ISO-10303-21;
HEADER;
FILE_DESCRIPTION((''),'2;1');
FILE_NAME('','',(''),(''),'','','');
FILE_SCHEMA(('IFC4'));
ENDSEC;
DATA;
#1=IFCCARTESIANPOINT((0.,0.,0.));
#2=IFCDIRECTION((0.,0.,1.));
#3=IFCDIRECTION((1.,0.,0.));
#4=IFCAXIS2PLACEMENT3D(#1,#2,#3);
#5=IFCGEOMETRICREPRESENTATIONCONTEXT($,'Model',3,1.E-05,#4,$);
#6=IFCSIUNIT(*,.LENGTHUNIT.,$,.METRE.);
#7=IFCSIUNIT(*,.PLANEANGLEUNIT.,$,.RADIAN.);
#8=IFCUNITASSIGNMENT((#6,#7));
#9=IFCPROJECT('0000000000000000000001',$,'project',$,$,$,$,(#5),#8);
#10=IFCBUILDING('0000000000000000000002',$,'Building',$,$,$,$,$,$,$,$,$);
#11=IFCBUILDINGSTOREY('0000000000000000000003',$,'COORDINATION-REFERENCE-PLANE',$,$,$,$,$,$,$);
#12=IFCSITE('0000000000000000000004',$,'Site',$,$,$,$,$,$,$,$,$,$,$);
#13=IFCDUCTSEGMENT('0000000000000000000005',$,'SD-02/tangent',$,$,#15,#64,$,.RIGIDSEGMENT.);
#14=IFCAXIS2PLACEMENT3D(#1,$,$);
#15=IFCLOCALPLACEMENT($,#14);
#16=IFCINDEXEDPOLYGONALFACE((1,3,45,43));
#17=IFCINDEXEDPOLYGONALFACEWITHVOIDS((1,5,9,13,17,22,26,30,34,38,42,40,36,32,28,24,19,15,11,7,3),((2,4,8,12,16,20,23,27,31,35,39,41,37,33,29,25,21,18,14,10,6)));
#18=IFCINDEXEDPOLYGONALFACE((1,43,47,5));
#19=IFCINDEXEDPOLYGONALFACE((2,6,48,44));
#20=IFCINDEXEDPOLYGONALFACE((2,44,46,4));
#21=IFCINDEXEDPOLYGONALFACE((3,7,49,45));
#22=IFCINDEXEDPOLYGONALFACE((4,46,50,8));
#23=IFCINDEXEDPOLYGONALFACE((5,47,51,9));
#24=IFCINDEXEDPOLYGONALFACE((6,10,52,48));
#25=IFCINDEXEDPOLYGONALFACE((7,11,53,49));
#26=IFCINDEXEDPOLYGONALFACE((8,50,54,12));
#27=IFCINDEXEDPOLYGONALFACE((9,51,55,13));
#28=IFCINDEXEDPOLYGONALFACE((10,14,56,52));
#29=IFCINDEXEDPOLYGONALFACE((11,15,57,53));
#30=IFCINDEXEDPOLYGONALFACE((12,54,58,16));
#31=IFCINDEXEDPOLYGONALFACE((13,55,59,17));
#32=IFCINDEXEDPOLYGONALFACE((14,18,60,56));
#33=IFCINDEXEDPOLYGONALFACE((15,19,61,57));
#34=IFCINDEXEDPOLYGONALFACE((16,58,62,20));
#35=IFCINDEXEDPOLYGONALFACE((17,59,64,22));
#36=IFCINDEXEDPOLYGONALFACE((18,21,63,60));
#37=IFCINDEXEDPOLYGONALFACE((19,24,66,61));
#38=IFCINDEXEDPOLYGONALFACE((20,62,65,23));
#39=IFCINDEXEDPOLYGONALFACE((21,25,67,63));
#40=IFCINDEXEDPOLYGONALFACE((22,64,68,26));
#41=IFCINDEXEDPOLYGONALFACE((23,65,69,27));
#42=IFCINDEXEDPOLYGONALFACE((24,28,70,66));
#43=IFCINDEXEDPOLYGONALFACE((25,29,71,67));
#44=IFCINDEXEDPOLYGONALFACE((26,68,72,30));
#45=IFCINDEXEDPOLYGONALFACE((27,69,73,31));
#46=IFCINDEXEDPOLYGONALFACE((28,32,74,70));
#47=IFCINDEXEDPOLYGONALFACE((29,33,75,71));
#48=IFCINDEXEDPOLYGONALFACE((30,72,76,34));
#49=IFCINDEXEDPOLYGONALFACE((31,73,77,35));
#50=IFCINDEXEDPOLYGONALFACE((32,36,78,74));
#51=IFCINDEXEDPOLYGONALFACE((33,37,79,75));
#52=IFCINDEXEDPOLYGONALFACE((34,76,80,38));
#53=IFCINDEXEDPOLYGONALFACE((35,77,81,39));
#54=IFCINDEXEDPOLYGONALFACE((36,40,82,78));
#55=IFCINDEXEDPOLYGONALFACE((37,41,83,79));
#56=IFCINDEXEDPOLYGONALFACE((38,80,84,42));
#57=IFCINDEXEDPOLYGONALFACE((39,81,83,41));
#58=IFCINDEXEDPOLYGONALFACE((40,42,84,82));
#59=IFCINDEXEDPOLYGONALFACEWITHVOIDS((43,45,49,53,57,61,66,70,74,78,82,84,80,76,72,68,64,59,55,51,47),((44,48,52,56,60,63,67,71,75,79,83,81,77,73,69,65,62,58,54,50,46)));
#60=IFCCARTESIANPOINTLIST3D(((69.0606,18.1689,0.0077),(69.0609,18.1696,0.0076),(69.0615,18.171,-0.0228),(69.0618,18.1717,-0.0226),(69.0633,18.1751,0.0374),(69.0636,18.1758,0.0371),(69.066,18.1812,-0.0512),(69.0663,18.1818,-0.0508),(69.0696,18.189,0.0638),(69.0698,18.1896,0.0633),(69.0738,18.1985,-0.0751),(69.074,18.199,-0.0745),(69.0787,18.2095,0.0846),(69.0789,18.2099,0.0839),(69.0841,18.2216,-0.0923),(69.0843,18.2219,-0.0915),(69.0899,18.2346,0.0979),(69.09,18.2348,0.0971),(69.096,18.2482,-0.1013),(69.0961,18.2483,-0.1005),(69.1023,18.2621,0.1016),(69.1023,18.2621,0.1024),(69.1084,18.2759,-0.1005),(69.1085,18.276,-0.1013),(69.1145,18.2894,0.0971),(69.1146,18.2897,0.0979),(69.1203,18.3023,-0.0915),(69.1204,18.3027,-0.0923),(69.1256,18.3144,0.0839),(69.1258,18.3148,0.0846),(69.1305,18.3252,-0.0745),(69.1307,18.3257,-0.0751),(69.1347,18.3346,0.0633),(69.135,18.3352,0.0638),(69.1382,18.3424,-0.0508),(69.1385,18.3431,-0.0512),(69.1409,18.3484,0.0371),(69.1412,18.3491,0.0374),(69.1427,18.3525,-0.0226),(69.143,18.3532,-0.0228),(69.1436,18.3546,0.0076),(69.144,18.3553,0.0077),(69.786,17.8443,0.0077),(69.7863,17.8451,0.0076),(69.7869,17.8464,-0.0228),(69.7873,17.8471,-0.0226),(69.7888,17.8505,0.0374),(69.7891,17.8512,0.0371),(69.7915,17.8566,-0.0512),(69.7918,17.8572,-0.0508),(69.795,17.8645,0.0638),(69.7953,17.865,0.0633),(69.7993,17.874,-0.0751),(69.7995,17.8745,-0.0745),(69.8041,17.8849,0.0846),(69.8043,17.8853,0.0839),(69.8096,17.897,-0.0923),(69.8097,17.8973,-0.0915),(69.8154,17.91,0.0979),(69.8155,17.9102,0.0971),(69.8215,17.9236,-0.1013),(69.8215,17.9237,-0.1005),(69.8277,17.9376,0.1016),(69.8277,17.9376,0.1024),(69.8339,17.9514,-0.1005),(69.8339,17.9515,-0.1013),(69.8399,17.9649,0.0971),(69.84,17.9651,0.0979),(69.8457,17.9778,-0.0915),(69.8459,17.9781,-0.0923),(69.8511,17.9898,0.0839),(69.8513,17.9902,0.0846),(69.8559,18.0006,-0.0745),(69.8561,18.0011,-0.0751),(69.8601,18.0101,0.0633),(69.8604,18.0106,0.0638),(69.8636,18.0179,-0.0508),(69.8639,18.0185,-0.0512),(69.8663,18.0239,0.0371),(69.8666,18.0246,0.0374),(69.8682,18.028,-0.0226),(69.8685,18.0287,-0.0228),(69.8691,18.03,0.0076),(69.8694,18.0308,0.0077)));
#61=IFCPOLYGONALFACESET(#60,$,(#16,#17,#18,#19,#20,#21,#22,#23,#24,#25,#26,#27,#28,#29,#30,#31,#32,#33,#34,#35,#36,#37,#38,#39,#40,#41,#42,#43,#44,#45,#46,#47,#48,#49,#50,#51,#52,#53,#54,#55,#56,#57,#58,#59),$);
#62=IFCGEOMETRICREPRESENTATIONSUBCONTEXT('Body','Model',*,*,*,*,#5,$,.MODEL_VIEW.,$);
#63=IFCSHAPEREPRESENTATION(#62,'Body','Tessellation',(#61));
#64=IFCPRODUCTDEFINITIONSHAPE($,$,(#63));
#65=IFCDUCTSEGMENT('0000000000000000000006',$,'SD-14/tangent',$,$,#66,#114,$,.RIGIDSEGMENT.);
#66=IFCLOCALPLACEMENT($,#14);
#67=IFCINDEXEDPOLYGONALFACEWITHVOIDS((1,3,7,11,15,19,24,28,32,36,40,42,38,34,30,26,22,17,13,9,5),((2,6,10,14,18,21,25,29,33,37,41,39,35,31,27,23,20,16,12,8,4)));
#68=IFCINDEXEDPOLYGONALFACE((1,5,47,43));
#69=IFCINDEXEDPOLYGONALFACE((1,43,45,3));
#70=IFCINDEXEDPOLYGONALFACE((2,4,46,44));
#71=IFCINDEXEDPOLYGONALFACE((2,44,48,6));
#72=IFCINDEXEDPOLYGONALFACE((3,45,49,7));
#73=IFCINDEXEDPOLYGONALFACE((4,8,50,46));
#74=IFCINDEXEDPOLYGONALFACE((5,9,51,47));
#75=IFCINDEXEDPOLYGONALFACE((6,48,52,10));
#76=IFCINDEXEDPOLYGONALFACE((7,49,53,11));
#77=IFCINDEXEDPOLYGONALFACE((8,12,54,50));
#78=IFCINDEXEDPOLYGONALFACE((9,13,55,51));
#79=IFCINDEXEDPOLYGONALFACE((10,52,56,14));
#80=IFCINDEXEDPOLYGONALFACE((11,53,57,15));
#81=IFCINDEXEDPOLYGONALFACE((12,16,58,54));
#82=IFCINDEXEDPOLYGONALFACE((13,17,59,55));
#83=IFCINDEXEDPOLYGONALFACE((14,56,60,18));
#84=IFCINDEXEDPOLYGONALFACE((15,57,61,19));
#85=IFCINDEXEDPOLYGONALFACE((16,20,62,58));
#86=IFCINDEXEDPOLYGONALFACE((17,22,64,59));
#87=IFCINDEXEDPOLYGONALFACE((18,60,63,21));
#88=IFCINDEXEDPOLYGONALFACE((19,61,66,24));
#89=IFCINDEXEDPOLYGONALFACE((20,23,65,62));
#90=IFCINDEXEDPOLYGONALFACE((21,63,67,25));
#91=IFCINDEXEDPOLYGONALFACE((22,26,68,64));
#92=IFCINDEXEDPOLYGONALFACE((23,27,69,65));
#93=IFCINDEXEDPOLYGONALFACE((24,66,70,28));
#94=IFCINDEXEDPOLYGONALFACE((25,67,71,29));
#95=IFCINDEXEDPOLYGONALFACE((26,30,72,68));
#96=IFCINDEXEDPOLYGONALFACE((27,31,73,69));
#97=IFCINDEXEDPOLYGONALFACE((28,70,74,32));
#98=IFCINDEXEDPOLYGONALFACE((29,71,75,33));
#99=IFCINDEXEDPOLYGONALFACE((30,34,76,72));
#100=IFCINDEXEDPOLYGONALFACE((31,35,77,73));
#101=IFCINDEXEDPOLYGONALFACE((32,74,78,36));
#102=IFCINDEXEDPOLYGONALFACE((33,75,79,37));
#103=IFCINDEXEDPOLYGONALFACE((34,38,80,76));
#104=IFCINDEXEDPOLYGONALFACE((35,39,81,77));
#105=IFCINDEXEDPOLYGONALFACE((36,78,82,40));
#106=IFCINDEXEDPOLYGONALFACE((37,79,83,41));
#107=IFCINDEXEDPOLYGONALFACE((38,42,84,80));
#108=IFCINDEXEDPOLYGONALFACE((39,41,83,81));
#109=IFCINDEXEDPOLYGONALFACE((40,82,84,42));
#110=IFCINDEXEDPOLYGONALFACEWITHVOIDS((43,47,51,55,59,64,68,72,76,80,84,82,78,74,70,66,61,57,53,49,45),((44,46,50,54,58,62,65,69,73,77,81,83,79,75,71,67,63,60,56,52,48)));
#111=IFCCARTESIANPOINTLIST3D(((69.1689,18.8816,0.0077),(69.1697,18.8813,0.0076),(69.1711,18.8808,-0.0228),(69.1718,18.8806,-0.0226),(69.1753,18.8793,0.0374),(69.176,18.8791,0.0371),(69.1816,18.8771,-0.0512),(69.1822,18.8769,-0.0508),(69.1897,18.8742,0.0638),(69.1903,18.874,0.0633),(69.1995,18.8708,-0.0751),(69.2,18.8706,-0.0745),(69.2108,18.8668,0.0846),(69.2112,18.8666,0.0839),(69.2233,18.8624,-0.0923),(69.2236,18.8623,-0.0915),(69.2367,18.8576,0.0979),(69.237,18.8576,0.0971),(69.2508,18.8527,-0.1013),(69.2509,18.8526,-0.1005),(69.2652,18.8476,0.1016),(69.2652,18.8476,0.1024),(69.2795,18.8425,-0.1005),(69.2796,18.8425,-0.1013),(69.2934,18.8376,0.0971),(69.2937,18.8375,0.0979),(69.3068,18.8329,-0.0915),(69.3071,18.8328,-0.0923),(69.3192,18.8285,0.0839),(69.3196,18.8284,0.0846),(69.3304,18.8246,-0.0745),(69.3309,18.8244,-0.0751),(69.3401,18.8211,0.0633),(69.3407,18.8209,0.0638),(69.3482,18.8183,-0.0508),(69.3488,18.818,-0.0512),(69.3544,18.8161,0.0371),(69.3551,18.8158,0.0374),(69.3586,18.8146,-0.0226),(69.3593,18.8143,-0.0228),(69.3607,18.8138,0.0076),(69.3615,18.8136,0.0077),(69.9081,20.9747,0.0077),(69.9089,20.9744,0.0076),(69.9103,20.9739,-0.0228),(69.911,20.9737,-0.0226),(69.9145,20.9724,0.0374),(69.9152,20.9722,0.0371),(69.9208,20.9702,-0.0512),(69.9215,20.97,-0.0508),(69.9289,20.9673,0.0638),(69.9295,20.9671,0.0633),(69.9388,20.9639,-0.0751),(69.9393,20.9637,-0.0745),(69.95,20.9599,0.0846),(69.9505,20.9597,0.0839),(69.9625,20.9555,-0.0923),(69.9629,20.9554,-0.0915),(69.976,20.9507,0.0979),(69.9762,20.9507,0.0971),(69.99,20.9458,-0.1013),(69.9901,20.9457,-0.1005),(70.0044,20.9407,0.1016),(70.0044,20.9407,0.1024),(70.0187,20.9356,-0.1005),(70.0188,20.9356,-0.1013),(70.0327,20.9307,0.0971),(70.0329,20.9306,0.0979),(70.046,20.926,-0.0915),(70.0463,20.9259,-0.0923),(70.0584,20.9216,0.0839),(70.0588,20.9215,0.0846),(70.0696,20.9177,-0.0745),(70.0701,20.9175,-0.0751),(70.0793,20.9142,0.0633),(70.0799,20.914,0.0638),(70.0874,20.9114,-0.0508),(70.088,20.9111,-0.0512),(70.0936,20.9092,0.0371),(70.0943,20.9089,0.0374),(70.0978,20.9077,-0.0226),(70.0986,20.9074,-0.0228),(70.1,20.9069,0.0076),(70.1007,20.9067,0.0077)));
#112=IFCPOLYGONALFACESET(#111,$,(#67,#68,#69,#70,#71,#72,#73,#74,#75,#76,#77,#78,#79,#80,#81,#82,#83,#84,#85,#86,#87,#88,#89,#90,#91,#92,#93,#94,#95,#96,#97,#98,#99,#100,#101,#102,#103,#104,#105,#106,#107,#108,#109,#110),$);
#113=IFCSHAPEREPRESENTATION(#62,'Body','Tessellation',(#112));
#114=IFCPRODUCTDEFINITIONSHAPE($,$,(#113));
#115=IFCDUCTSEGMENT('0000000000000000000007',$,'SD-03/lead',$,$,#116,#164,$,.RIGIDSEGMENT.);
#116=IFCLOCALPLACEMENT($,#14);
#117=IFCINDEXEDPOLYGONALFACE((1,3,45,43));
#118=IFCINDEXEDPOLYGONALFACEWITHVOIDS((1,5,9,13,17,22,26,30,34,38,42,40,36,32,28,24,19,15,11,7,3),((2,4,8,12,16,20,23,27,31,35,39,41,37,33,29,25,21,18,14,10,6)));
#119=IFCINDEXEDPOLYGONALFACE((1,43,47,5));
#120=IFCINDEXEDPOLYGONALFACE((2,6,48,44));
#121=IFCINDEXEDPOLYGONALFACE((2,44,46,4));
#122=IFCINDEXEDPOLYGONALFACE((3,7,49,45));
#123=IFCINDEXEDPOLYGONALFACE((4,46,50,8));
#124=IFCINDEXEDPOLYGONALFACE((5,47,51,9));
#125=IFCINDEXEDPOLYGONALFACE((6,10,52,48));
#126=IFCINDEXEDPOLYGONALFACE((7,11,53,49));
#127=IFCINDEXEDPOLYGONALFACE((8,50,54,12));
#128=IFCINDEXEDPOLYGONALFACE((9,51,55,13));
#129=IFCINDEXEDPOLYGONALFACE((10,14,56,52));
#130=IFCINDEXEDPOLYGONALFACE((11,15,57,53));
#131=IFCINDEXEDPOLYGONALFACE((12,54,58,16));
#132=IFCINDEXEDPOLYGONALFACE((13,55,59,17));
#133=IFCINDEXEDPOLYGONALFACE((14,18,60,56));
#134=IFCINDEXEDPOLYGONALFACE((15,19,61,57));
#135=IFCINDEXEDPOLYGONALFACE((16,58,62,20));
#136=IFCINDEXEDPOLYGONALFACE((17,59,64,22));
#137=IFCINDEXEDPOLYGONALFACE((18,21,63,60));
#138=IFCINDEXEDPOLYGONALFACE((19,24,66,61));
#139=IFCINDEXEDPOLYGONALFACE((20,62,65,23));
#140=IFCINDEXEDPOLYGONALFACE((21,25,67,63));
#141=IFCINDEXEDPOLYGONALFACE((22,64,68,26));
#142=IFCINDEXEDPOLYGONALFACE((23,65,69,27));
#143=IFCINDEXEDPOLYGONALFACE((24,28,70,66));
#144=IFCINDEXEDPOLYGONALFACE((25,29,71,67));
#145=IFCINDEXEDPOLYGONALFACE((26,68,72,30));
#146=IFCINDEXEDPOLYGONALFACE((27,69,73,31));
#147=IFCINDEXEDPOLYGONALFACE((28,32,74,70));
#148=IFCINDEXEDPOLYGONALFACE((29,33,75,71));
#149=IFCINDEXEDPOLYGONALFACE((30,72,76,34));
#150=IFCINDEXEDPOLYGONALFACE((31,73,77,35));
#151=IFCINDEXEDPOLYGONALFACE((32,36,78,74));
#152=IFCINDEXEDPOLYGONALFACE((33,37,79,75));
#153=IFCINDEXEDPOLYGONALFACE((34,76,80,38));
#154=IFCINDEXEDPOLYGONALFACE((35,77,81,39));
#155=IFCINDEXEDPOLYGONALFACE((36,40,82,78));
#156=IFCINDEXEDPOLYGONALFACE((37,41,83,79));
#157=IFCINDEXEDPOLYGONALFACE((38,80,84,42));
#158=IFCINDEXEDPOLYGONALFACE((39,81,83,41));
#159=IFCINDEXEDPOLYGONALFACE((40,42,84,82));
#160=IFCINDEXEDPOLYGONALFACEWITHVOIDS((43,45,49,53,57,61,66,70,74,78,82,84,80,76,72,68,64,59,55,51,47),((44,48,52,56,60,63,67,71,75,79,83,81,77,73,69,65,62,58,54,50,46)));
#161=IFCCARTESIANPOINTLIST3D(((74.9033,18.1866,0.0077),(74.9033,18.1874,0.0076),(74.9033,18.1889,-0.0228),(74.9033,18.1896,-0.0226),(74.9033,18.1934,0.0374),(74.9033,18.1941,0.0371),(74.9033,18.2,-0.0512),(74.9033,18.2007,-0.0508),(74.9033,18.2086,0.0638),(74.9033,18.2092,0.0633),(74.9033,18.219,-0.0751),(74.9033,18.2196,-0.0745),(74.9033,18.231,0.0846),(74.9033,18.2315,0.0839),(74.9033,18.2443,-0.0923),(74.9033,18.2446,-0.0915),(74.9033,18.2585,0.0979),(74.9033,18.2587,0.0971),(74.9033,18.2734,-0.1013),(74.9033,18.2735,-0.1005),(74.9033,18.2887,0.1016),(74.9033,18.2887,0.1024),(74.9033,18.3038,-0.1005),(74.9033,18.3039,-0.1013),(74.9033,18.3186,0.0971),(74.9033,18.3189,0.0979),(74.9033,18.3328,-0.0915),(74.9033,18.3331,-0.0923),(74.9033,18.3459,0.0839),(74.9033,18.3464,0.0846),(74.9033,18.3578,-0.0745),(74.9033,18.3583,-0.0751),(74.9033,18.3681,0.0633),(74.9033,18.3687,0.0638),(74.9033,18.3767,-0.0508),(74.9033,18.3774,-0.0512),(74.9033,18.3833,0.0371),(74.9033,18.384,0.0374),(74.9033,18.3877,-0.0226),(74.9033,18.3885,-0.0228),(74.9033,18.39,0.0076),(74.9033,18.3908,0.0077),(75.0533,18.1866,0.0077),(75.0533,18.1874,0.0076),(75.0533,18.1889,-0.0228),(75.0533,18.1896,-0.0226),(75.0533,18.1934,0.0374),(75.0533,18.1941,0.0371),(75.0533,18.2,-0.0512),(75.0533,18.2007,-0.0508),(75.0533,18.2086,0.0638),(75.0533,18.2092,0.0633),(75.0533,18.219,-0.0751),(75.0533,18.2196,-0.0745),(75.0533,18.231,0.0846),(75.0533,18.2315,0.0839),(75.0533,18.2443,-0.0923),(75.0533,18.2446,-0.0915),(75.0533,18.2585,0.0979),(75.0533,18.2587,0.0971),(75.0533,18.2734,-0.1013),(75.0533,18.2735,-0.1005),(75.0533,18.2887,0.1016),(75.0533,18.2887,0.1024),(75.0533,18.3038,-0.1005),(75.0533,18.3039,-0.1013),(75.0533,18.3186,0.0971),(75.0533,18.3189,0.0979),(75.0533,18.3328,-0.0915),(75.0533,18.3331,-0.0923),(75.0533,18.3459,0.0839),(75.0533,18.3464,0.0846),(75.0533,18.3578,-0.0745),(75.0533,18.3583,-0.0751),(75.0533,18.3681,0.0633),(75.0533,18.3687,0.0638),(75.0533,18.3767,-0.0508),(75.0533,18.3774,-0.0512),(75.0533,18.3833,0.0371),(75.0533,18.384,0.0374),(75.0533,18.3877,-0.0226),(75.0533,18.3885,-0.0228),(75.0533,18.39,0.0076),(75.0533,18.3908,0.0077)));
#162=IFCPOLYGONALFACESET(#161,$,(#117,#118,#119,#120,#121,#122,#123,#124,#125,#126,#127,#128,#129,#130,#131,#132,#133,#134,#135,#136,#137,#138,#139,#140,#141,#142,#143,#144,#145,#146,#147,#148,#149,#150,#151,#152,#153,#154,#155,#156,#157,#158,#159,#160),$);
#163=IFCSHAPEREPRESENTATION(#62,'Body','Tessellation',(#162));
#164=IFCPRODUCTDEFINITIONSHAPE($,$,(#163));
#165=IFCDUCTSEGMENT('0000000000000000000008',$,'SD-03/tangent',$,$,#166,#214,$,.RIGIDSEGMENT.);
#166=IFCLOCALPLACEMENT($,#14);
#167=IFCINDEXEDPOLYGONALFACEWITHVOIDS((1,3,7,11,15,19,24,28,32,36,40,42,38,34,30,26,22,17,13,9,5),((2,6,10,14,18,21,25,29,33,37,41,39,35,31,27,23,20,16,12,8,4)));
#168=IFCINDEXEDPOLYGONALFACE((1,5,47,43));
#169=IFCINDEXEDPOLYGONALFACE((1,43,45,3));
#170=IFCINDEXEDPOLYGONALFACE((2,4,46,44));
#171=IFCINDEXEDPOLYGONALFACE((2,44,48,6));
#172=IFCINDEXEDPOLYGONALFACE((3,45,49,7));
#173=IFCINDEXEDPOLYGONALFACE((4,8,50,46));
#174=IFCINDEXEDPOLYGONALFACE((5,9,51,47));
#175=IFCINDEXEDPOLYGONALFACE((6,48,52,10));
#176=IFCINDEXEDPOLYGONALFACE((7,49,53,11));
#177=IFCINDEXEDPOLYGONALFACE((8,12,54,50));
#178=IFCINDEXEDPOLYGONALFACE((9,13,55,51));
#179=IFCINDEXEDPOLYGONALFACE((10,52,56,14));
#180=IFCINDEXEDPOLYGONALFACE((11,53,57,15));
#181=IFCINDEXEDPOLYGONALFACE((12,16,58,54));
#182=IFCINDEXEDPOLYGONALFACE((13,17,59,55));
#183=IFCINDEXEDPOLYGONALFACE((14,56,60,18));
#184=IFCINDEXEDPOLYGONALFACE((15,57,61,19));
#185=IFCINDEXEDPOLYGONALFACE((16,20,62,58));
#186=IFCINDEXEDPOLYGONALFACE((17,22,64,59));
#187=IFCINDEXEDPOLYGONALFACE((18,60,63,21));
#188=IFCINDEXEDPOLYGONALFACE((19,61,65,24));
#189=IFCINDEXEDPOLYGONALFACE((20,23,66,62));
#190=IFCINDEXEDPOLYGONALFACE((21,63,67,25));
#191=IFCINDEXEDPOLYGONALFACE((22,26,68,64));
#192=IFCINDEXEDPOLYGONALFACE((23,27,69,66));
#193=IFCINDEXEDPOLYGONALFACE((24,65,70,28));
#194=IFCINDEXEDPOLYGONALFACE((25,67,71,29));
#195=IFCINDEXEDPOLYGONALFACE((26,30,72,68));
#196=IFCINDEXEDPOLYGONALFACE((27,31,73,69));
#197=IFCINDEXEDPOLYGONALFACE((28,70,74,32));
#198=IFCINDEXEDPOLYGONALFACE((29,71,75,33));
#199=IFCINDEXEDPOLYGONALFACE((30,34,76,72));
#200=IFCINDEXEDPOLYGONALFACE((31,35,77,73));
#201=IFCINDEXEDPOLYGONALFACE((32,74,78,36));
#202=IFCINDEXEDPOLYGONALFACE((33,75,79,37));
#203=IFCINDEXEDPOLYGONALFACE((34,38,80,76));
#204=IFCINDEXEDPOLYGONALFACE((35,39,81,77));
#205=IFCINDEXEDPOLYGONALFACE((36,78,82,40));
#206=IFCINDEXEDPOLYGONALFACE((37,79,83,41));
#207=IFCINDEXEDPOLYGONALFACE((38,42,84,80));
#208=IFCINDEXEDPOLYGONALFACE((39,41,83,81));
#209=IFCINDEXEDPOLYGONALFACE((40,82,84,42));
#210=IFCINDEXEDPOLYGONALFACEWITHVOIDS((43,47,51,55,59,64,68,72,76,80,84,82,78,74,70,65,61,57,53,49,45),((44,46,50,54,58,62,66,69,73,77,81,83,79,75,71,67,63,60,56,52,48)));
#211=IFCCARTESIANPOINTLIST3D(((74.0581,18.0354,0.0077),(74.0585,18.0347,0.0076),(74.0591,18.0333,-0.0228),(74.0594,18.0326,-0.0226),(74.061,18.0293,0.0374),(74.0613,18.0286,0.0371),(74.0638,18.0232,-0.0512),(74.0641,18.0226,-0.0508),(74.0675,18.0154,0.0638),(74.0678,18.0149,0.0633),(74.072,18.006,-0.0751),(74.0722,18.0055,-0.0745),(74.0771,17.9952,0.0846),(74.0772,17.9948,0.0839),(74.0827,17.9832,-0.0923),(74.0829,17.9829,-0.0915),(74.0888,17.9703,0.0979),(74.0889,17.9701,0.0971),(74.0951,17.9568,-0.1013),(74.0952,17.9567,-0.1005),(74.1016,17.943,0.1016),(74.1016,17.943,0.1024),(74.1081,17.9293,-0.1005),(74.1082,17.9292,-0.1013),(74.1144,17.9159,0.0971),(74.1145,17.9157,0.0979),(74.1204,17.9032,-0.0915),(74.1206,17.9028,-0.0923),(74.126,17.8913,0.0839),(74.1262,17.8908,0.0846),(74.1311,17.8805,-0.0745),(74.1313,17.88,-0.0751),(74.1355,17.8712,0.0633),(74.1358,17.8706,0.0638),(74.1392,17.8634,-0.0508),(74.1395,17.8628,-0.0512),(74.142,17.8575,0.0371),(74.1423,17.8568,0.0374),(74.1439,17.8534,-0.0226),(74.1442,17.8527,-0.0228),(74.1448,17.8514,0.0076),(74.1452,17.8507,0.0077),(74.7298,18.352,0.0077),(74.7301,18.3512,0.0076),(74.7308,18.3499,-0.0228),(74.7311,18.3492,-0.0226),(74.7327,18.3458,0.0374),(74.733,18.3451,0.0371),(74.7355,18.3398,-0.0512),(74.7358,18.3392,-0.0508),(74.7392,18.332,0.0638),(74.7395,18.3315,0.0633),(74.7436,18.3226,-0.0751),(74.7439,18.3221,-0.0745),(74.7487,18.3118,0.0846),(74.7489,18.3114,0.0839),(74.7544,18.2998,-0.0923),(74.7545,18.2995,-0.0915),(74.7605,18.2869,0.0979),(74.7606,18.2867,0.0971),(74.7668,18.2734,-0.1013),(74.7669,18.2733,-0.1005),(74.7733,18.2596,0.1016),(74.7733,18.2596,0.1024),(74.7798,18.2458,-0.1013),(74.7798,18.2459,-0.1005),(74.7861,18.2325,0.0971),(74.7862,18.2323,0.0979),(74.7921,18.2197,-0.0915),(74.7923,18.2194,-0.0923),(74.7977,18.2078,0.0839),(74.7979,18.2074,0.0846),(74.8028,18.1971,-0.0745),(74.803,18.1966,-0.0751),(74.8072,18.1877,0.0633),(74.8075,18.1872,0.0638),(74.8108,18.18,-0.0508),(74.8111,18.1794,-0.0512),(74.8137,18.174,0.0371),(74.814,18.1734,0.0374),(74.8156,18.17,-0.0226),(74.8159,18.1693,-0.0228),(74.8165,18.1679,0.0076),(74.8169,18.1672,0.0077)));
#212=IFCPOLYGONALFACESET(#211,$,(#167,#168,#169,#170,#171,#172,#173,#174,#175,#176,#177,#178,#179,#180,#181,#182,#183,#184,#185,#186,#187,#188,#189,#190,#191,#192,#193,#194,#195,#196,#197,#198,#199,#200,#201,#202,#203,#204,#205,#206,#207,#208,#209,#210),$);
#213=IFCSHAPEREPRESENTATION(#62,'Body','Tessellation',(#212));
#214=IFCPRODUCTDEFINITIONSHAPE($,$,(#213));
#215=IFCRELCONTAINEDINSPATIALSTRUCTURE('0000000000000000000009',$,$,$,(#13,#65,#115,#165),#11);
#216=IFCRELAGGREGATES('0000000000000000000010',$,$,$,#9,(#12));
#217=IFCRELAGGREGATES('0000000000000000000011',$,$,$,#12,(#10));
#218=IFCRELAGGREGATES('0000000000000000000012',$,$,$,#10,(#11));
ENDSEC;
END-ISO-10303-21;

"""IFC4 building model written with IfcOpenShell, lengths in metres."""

from ifc_helpers import new_model, si_unit, frame, origin_with_axes, place, context, subcontext, project, spatial, hollow_circle, extrude, element, save


model = new_model("IFC4")

# Units and contexts
model_context = context("Model", 3, precision=1e-05, world=origin_with_axes())
body_context_1 = subcontext(model_context, "Body", "Model", "MODEL_VIEW")
ifc_project = project(units=[si_unit("LENGTHUNIT", "METRE"), si_unit("PLANEANGLEUNIT", "RADIAN")], contexts=[model_context])

# Site, building, storey
site = spatial("IfcSite", under=ifc_project, Name="Site")
building = spatial("IfcBuilding", under=site, Name="Building")
storey = spatial("IfcBuildingStorey", under=building, Name="COORDINATION-REFERENCE-PLANE")

# Duct segment
duct_segment_1_placement = place(None, frame((69.1023, 18.2621, 0.0), z_axis=(0.912813, -0.408378, 0.0), x_axis=(0.0, 0.0, 1.0)))
element("IfcDuctSegment", 1, at=duct_segment_1_placement, inside=storey, Name="SD-02/tangent", PredefinedType="RIGIDSEGMENT", context=body_context_1, shape_type="SweptSolid", body=[
    extrude(hollow_circle(Radius=0.1024, WallThickness=0.0008), origin_with_axes(), (0.0, 0.0, 1.0), 0.7947),
])

# Duct segment
duct_segment_2_placement = place(None, frame((69.2652, 18.8476, 0.0), z_axis=(0.333018, 0.94292, 0.0), x_axis=(0.0, 0.0, 1.0)))
element("IfcDuctSegment", 2, at=duct_segment_2_placement, inside=storey, Name="SD-14/tangent", PredefinedType="RIGIDSEGMENT", context=body_context_1, shape_type="SweptSolid", body=[
    extrude(hollow_circle(Radius=0.1024, WallThickness=0.0008), origin_with_axes(), (0.0, 0.0, 1.0), 2.2198),
])

# Duct segment
duct_segment_3_placement = place(None, frame((75.0533, 18.2887, 0.0), z_axis=(-1.0, 0.0, 0.0), x_axis=(0.0, 0.0, 1.0)))
element("IfcDuctSegment", 3, at=duct_segment_3_placement, inside=storey, Name="SD-03/lead", PredefinedType="RIGIDSEGMENT", context=body_context_1, shape_type="SweptSolid", body=[
    extrude(hollow_circle(Radius=0.1024, WallThickness=0.0008), origin_with_axes(), (0.0, 0.0, 1.0), 0.15),
])

# Duct segment
duct_segment_4_placement = place(None, frame((74.7733, 18.2596, 0.0), z_axis=(-0.904569, -0.426327, 0.0), x_axis=(0.0, 0.0, 1.0)))
element("IfcDuctSegment", 4, at=duct_segment_4_placement, inside=storey, Name="SD-03/tangent", PredefinedType="RIGIDSEGMENT", context=body_context_1, shape_type="SweptSolid", body=[
    extrude(hollow_circle(Radius=0.1024, WallThickness=0.0008), origin_with_axes(), (0.0, 0.0, 1.0), 0.7425),
])

save(model, "model.ifc")
